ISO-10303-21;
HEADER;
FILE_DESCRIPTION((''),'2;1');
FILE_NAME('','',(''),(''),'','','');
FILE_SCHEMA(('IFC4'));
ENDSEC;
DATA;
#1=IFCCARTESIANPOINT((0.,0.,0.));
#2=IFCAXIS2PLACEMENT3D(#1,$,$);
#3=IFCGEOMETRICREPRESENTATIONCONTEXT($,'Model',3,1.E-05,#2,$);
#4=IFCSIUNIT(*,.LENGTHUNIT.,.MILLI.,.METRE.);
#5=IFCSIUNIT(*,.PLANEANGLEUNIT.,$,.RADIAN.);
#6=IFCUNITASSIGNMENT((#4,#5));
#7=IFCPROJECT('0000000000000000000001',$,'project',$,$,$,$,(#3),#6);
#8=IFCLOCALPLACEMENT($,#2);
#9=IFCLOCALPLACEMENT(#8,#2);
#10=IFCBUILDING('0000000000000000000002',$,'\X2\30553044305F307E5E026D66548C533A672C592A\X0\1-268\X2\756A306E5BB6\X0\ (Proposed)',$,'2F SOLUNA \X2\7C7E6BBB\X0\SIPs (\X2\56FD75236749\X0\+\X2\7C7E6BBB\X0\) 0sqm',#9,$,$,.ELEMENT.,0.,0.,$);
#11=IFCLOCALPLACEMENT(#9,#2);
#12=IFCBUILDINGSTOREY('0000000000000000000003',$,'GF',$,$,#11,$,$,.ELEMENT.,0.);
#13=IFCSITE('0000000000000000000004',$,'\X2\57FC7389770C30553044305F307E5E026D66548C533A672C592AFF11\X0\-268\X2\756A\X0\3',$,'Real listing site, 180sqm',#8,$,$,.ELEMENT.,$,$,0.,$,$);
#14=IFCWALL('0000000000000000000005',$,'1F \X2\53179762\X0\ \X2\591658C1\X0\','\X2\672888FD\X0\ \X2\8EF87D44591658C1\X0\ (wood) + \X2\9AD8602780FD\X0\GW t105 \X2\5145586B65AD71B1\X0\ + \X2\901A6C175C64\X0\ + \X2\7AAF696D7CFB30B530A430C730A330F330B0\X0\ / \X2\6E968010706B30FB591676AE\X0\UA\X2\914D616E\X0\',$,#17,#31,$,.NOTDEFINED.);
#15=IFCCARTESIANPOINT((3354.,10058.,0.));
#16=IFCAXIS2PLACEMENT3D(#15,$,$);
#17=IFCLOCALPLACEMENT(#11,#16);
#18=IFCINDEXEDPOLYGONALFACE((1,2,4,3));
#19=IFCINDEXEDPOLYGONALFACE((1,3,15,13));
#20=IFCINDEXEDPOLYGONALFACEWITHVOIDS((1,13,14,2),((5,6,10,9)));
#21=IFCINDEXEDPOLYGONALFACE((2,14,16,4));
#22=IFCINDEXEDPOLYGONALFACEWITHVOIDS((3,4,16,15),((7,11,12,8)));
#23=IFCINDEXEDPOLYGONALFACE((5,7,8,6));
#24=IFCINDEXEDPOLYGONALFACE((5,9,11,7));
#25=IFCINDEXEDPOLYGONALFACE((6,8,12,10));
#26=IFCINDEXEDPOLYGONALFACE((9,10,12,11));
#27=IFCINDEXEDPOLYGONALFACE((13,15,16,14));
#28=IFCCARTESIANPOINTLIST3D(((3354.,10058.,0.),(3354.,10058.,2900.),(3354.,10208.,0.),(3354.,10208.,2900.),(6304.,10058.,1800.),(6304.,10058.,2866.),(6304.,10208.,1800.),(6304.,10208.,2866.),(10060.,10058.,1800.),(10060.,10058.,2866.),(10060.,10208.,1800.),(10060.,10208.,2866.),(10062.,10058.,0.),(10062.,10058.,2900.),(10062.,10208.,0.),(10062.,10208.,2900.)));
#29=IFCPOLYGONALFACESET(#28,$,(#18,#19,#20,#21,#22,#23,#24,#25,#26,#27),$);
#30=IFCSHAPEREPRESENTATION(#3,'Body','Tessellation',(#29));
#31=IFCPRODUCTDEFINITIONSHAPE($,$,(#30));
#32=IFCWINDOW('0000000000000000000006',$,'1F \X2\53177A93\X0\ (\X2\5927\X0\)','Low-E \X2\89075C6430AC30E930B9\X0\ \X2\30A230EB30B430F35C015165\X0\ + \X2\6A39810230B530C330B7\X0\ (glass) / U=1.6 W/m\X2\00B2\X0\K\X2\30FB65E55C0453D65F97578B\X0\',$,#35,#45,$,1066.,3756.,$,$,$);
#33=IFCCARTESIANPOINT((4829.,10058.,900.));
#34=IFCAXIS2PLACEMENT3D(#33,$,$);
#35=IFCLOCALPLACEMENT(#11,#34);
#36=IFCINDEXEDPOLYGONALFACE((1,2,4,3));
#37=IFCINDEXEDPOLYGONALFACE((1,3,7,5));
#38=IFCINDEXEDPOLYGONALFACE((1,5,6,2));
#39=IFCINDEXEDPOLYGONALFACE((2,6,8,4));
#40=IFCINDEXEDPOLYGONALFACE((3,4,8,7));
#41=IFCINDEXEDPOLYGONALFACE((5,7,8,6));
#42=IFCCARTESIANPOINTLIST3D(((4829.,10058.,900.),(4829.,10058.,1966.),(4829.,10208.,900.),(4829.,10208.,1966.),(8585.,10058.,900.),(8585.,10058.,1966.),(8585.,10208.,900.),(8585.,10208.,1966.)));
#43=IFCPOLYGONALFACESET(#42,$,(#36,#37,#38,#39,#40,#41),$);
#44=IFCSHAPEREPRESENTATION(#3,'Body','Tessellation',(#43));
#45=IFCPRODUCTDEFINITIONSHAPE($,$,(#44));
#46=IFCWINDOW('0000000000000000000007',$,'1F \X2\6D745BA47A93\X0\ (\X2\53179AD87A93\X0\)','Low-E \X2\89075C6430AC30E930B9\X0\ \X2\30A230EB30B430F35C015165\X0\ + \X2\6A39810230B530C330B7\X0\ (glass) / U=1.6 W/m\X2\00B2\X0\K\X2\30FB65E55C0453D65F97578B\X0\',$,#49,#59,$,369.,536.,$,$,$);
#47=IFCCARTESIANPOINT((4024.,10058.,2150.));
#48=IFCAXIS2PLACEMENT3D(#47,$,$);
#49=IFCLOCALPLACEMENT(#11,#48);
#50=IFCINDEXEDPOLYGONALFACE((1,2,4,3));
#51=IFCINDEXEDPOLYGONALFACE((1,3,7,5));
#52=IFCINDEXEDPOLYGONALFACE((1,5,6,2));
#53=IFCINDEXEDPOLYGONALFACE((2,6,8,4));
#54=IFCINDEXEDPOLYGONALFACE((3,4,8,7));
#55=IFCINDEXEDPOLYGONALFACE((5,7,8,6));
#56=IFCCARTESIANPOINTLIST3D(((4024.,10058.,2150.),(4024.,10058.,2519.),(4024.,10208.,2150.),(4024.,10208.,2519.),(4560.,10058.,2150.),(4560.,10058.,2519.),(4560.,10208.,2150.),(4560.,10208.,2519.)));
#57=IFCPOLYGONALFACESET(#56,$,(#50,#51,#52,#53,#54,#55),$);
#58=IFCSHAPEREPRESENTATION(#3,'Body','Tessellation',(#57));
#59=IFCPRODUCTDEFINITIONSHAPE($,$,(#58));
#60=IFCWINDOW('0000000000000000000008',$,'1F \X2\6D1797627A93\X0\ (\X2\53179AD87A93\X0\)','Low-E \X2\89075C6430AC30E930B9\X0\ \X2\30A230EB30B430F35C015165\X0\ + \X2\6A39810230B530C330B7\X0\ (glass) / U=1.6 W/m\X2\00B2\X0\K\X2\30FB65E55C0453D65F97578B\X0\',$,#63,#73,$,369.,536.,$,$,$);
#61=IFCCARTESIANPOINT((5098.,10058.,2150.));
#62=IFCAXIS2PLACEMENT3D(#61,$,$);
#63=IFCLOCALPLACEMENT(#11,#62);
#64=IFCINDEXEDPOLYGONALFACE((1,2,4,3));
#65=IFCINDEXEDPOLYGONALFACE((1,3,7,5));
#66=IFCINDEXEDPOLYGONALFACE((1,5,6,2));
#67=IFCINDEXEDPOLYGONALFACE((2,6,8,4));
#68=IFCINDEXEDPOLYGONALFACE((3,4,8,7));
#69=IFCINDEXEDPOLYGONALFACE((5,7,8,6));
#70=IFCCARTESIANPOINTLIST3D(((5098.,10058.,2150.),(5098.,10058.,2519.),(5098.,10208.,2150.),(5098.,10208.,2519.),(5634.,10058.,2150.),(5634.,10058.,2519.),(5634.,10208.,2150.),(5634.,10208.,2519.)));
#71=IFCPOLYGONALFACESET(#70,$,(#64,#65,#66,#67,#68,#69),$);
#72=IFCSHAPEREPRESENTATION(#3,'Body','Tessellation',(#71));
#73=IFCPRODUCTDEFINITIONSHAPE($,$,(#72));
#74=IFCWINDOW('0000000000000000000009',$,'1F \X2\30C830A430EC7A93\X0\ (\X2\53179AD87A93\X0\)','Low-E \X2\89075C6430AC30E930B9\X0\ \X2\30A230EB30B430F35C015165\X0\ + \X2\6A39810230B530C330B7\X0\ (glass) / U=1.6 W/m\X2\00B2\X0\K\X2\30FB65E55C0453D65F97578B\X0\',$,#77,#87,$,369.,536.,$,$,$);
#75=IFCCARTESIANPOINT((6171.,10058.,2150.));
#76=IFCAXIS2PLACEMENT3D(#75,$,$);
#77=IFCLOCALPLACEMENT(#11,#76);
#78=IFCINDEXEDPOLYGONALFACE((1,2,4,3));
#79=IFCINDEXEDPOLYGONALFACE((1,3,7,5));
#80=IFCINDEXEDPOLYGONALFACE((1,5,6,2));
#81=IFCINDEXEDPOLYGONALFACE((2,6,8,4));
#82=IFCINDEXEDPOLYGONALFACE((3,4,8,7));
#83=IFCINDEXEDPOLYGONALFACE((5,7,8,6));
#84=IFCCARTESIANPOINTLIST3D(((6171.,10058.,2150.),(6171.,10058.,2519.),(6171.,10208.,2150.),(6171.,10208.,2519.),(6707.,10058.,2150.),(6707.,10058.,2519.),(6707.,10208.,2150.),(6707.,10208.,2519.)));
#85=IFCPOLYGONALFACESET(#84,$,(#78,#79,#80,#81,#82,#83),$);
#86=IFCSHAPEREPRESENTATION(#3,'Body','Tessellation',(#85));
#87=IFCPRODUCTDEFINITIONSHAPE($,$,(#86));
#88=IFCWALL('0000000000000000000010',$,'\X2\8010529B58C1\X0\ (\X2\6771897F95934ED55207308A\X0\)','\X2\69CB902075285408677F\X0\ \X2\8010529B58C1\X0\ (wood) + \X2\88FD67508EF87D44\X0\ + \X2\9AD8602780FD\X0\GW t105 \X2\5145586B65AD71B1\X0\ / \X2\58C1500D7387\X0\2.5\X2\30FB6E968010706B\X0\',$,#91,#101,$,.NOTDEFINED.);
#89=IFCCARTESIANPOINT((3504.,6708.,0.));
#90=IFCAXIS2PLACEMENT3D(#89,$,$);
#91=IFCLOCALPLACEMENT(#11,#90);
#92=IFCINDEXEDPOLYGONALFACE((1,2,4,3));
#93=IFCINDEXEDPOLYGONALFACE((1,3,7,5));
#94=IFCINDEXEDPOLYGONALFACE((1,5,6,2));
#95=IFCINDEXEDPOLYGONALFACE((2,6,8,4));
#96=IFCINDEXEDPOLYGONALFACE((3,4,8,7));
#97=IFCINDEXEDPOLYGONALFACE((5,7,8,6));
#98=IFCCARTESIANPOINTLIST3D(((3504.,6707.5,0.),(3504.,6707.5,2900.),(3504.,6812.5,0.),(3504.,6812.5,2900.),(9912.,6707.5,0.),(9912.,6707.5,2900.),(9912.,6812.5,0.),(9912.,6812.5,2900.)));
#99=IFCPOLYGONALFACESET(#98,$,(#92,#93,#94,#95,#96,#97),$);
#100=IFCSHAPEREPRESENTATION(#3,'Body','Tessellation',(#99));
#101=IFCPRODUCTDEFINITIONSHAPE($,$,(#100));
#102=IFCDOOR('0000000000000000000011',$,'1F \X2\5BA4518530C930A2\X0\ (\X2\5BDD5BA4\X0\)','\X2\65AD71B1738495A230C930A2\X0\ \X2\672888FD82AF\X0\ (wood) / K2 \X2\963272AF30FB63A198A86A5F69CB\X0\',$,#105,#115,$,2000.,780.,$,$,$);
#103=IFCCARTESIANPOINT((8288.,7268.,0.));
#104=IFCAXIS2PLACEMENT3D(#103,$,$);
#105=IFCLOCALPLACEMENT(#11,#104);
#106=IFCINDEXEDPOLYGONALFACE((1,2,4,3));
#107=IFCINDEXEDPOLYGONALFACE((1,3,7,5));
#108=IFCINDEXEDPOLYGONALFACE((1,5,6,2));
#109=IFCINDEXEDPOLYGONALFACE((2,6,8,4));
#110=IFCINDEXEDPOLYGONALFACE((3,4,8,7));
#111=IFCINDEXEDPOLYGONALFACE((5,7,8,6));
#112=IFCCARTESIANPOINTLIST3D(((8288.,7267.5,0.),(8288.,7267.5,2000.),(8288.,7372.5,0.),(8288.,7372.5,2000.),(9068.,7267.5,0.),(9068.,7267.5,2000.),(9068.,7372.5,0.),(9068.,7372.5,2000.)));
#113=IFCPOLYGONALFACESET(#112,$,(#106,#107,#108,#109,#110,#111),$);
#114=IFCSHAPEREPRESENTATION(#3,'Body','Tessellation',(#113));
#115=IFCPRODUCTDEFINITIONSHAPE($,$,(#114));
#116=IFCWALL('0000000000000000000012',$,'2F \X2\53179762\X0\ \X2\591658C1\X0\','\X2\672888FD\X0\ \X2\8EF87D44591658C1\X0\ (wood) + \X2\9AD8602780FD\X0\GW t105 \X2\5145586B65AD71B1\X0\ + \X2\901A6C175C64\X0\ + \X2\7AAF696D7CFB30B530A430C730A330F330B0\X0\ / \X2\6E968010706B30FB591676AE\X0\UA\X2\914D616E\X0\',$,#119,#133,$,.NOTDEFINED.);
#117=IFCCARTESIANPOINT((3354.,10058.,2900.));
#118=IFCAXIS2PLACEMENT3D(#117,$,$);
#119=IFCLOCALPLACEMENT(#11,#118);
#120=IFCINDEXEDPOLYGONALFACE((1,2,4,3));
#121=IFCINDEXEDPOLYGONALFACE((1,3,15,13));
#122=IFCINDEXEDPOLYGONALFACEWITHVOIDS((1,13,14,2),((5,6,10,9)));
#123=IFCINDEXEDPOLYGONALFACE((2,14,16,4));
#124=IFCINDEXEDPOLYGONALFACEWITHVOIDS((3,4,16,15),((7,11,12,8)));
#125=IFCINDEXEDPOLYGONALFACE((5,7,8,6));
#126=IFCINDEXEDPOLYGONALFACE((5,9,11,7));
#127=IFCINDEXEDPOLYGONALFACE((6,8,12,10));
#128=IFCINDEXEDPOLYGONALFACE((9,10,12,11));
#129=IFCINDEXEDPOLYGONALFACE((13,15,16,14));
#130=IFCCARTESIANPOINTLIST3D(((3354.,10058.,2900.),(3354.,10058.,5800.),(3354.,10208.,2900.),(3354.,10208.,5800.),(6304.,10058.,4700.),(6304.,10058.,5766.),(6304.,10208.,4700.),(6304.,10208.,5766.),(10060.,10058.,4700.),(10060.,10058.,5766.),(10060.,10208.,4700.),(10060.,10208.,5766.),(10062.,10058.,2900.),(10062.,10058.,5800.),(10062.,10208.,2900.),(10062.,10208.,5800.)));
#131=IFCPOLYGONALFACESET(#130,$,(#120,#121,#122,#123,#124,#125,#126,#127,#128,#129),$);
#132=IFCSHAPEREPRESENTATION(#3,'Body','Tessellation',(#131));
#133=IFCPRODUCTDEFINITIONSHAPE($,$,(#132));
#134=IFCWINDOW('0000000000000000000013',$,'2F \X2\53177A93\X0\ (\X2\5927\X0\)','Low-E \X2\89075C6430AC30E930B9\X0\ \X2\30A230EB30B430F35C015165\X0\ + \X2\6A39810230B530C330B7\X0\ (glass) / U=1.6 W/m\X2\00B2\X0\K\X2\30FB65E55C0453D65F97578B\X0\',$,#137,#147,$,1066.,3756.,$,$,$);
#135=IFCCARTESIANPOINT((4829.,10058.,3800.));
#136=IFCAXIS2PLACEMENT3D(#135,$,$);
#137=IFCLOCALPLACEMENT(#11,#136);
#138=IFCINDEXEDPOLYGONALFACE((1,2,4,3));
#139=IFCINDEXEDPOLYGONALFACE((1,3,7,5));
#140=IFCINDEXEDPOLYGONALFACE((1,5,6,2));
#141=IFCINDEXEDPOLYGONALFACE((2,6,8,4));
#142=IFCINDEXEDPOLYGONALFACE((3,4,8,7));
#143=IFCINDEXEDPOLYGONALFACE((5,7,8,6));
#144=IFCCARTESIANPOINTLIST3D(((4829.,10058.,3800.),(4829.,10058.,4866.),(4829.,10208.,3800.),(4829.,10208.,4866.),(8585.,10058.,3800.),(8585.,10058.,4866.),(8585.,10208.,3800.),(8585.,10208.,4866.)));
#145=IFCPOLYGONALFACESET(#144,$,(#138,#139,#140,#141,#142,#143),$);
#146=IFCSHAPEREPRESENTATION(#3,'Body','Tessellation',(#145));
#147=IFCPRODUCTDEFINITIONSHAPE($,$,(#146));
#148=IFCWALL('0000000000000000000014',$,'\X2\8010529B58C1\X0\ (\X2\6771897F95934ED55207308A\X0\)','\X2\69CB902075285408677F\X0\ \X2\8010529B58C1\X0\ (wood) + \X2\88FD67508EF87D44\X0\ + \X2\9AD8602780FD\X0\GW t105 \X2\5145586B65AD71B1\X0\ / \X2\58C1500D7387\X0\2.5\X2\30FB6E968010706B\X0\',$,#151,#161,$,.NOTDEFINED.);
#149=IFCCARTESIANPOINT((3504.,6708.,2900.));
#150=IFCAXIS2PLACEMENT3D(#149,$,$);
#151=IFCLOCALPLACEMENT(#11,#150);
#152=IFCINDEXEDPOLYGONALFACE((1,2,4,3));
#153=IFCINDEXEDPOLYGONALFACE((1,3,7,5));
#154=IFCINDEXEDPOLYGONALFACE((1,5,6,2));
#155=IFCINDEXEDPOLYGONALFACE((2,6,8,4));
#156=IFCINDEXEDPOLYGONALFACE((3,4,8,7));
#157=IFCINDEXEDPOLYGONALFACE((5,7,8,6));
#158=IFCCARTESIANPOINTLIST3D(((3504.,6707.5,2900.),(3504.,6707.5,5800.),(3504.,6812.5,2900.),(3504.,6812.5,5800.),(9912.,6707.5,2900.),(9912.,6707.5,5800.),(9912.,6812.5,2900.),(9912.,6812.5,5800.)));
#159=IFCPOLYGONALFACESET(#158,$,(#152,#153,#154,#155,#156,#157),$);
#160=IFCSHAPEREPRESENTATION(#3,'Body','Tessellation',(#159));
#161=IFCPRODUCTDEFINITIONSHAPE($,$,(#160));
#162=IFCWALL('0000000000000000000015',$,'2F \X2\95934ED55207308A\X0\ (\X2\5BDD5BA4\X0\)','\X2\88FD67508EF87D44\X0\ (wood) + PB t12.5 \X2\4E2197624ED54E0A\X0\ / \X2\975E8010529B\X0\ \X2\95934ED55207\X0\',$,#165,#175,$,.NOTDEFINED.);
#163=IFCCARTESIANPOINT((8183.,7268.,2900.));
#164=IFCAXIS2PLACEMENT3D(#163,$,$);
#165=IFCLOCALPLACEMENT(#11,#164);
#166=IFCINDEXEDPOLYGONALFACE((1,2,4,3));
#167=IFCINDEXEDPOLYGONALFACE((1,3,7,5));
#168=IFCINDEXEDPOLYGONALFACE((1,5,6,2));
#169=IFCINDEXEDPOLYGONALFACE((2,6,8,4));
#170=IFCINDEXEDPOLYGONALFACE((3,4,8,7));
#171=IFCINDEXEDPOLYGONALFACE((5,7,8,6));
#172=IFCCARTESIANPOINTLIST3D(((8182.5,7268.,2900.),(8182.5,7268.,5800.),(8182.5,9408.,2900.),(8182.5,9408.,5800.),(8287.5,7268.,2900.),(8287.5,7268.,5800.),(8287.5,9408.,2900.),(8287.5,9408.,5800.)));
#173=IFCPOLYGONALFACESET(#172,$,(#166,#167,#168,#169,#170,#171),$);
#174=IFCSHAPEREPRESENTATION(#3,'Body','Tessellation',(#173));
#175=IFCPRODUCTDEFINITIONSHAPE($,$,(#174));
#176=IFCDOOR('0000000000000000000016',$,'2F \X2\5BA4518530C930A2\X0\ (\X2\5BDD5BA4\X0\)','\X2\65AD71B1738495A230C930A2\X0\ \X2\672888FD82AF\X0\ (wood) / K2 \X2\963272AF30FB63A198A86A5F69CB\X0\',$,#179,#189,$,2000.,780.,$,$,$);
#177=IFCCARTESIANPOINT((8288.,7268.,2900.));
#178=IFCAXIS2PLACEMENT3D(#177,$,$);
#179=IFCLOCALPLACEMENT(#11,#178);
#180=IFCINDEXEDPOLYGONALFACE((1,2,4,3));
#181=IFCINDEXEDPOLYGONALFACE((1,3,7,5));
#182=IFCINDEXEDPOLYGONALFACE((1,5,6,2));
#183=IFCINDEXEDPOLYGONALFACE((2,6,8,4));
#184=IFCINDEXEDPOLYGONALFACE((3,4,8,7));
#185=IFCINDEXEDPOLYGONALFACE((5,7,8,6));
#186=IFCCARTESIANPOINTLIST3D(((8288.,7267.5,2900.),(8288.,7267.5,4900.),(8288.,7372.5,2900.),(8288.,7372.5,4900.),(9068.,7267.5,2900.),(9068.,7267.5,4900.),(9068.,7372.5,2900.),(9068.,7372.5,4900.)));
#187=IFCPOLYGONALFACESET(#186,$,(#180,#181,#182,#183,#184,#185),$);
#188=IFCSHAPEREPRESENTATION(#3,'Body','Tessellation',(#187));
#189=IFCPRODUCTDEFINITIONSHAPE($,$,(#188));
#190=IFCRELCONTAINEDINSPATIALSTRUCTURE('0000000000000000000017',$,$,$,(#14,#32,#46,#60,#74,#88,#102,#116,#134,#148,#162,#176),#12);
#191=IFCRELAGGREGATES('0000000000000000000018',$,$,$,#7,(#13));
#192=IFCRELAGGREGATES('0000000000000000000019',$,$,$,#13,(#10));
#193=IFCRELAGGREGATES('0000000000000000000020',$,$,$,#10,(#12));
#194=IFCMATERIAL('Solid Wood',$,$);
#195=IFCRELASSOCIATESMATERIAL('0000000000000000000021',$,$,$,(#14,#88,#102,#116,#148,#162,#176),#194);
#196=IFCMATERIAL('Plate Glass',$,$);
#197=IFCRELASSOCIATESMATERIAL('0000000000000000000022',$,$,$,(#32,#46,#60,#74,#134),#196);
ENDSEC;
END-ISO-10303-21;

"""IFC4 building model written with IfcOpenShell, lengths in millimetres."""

from ifc_helpers import new_model, si_unit, frame, frame_2d, origin, place, context, project, spatial, rectangle, extrude, material, element, fill, save


model = new_model("IFC4")

# Units and contexts
model_context = context("Model", 3, precision=1e-05, world=origin())
ifc_project = project(units=[si_unit("LENGTHUNIT", "METRE", prefix="MILLI"), si_unit("PLANEANGLEUNIT", "RADIAN")], contexts=[model_context])

# Site, building, storey
site_placement = place(None, origin())
site = spatial("IfcSite", under=ifc_project, at=site_placement, Name="埼玉県さいたま市浦和区本太１-268番3", ObjectType="Real listing site, 180sqm", CompositionType="ELEMENT", RefElevation=0.0)
building_placement = place(site_placement, origin())
building = spatial("IfcBuilding", under=site, at=building_placement, Name="さいたま市浦和区本太1-268番の家 (Proposed)", ObjectType="2F SOLUNA 籾殻SIPs (国産杉+籾殻) 0sqm", CompositionType="ELEMENT", ElevationOfRefHeight=0.0, ElevationOfTerrain=0.0)
storey_placement = place(building_placement, origin())
storey = spatial("IfcBuildingStorey", under=building, at=storey_placement, Name="GF", CompositionType="ELEMENT", Elevation=0.0)

# Wall, openings, windows
ifc_material_1 = material(Name="Solid Wood")
wall_1_placement = place(storey_placement, frame((3354.0, 10058.0, 0.0)))
wall_1 = element("IfcWall", 1, at=wall_1_placement, inside=storey, material=ifc_material_1, Name="1F 北面 外壁", Description="木製 軸組外壁 (wood) + 高性能GW t105 充填断熱 + 通気層 + 窯業系サイディング / 準耐火・外皮UA配慮", PredefinedType="NOTDEFINED", context=model_context, shape_type="SweptSolid", body=[
    extrude(rectangle(XDim=6708.0, YDim=150.0, at=frame_2d((3354.0, 75.0))), frame((3354.0, 10058.0, 0.0)), (0.0, 0.0, 1.0), 2900.0),
])
opening_1_placement = place(storey_placement, frame((4829.0, 10058.0, 900.0)))
opening_1 = element("IfcOpeningElement", 2, at=opening_1_placement, cuts=wall_1, PredefinedType="NOTDEFINED", context=model_context, shape_type="SweptSolid", body=[
    extrude(rectangle(XDim=3756.0, YDim=150.0, at=frame_2d((1878.0, 75.0))), frame((4829.0, 10058.0, 900.0)), (0.0, 0.0, 1.0), 1066.0),
])
opening_2_placement = place(storey_placement, frame((4024.0, 10058.0, 2150.0)))
opening_2 = element("IfcOpeningElement", 3, at=opening_2_placement, cuts=wall_1, PredefinedType="NOTDEFINED", context=model_context, shape_type="SweptSolid", body=[
    extrude(rectangle(XDim=536.0, YDim=150.0, at=frame_2d((268.0, 75.0))), frame((4024.0, 10058.0, 2150.0)), (0.0, 0.0, 1.0), 369.0),
])
opening_3_placement = place(storey_placement, frame((5098.0, 10058.0, 2150.0)))
opening_3 = element("IfcOpeningElement", 4, at=opening_3_placement, cuts=wall_1, PredefinedType="NOTDEFINED", context=model_context, shape_type="SweptSolid", body=[
    extrude(rectangle(XDim=536.0, YDim=150.0, at=frame_2d((268.0, 75.0))), frame((5098.0, 10058.0, 2150.0)), (0.0, 0.0, 1.0), 369.0),
])
opening_4_placement = place(storey_placement, frame((6171.0, 10058.0, 2150.0)))
opening_4 = element("IfcOpeningElement", 5, at=opening_4_placement, cuts=wall_1, PredefinedType="NOTDEFINED", context=model_context, shape_type="SweptSolid", body=[
    extrude(rectangle(XDim=536.0, YDim=150.0, at=frame_2d((268.0, 75.0))), frame((6171.0, 10058.0, 2150.0)), (0.0, 0.0, 1.0), 369.0),
])
ifc_material_2 = material(Name="Plate Glass")
window_1_placement = place(storey_placement, frame((4829.0, 10058.0, 900.0)))
window_1 = element("IfcWindow", 6, at=window_1_placement, inside=storey, material=ifc_material_2, Name="1F 北窓 (大)", Description="Low-E 複層ガラス アルゴン封入 + 樹脂サッシ (glass) / U=1.6 W/m²K・日射取得型", OverallHeight=1066.0, OverallWidth=3756.0, context=model_context, shape_type="SweptSolid", body=[
    extrude(rectangle(XDim=3756.0, YDim=150.0, at=frame_2d((1878.0, 75.0))), frame((4829.0, 10058.0, 900.0)), (0.0, 0.0, 1.0), 1066.0),
])
fill(opening_1, window_1)
window_2_placement = place(storey_placement, frame((4024.0, 10058.0, 2150.0)))
window_2 = element("IfcWindow", 7, at=window_2_placement, inside=storey, material=ifc_material_2, Name="1F 浴室窓 (北高窓)", Description="Low-E 複層ガラス アルゴン封入 + 樹脂サッシ (glass) / U=1.6 W/m²K・日射取得型", OverallHeight=369.0, OverallWidth=536.0, context=model_context, shape_type="SweptSolid", body=[
    extrude(rectangle(XDim=536.0, YDim=150.0, at=frame_2d((268.0, 75.0))), frame((4024.0, 10058.0, 2150.0)), (0.0, 0.0, 1.0), 369.0),
])
fill(opening_2, window_2)
window_3_placement = place(storey_placement, frame((5098.0, 10058.0, 2150.0)))
window_3 = element("IfcWindow", 8, at=window_3_placement, inside=storey, material=ifc_material_2, Name="1F 洗面窓 (北高窓)", Description="Low-E 複層ガラス アルゴン封入 + 樹脂サッシ (glass) / U=1.6 W/m²K・日射取得型", OverallHeight=369.0, OverallWidth=536.0, context=model_context, shape_type="SweptSolid", body=[
    extrude(rectangle(XDim=536.0, YDim=150.0, at=frame_2d((268.0, 75.0))), frame((5098.0, 10058.0, 2150.0)), (0.0, 0.0, 1.0), 369.0),
])
fill(opening_3, window_3)
window_4_placement = place(storey_placement, frame((6171.0, 10058.0, 2150.0)))
window_4 = element("IfcWindow", 9, at=window_4_placement, inside=storey, material=ifc_material_2, Name="1F トイレ窓 (北高窓)", Description="Low-E 複層ガラス アルゴン封入 + 樹脂サッシ (glass) / U=1.6 W/m²K・日射取得型", OverallHeight=369.0, OverallWidth=536.0, context=model_context, shape_type="SweptSolid", body=[
    extrude(rectangle(XDim=536.0, YDim=150.0, at=frame_2d((268.0, 75.0))), frame((6171.0, 10058.0, 2150.0)), (0.0, 0.0, 1.0), 369.0),
])
fill(opening_4, window_4)

# Wall
wall_2_placement = place(storey_placement, frame((3504.0, 6708.0, 0.0)))
element("IfcWall", 10, at=wall_2_placement, inside=storey, material=ifc_material_1, Name="耐力壁 (東西間仕切り)", Description="構造用合板 耐力壁 (wood) + 製材軸組 + 高性能GW t105 充填断熱 / 壁倍率2.5・準耐火", PredefinedType="NOTDEFINED", context=model_context, shape_type="SweptSolid", body=[
    extrude(rectangle(XDim=6408.0, YDim=105.0, at=frame_2d((3204.0, 52.0))), frame((3504.0, 6708.0, 0.0)), (0.0, 0.0, 1.0), 2900.0),
])

# Door
door_1_placement = place(storey_placement, frame((8288.0, 7268.0, 0.0)))
element("IfcDoor", 11, at=door_1_placement, inside=storey, material=ifc_material_1, Name="1F 室内ドア (寝室)", Description="断熱玄関ドア 木製芯 (wood) / K2 防犯・採風機構", OverallHeight=2000.0, OverallWidth=780.0, context=model_context, shape_type="SweptSolid", body=[
    extrude(rectangle(XDim=780.0, YDim=105.0, at=frame_2d((390.0, 52.0))), frame((8288.0, 7268.0, 0.0)), (0.0, 0.0, 1.0), 2000.0),
])

# Wall, opening, window
wall_3_placement = place(storey_placement, frame((3354.0, 10058.0, 2900.0)))
wall_3 = element("IfcWall", 12, at=wall_3_placement, inside=storey, material=ifc_material_1, Name="2F 北面 外壁", Description="木製 軸組外壁 (wood) + 高性能GW t105 充填断熱 + 通気層 + 窯業系サイディング / 準耐火・外皮UA配慮", PredefinedType="NOTDEFINED", context=model_context, shape_type="SweptSolid", body=[
    extrude(rectangle(XDim=6708.0, YDim=150.0, at=frame_2d((3354.0, 75.0))), frame((3354.0, 10058.0, 2900.0)), (0.0, 0.0, 1.0), 2900.0),
])
opening_5_placement = place(storey_placement, frame((4829.0, 10058.0, 3800.0)))
opening_5 = element("IfcOpeningElement", 13, at=opening_5_placement, cuts=wall_3, PredefinedType="NOTDEFINED", context=model_context, shape_type="SweptSolid", body=[
    extrude(rectangle(XDim=3756.0, YDim=150.0, at=frame_2d((1878.0, 75.0))), frame((4829.0, 10058.0, 3800.0)), (0.0, 0.0, 1.0), 1066.0),
])
window_5_placement = place(storey_placement, frame((4829.0, 10058.0, 3800.0)))
window_5 = element("IfcWindow", 14, at=window_5_placement, inside=storey, material=ifc_material_2, Name="2F 北窓 (大)", Description="Low-E 複層ガラス アルゴン封入 + 樹脂サッシ (glass) / U=1.6 W/m²K・日射取得型", OverallHeight=1066.0, OverallWidth=3756.0, context=model_context, shape_type="SweptSolid", body=[
    extrude(rectangle(XDim=3756.0, YDim=150.0, at=frame_2d((1878.0, 75.0))), frame((4829.0, 10058.0, 3800.0)), (0.0, 0.0, 1.0), 1066.0),
])
fill(opening_5, window_5)

# Walls
wall_4_placement = place(storey_placement, frame((3504.0, 6708.0, 2900.0)))
element("IfcWall", 15, at=wall_4_placement, inside=storey, material=ifc_material_1, Name="耐力壁 (東西間仕切り)", Description="構造用合板 耐力壁 (wood) + 製材軸組 + 高性能GW t105 充填断熱 / 壁倍率2.5・準耐火", PredefinedType="NOTDEFINED", context=model_context, shape_type="SweptSolid", body=[
    extrude(rectangle(XDim=6408.0, YDim=105.0, at=frame_2d((3204.0, 52.0))), frame((3504.0, 6708.0, 2900.0)), (0.0, 0.0, 1.0), 2900.0),
])
wall_5_placement = place(storey_placement, frame((8183.0, 7268.0, 2900.0)))
element("IfcWall", 16, at=wall_5_placement, inside=storey, material=ifc_material_1, Name="2F 間仕切り (寝室)", Description="製材軸組 (wood) + PB t12.5 両面仕上 / 非耐力 間仕切", PredefinedType="NOTDEFINED", context=model_context, shape_type="SweptSolid", body=[
    extrude(rectangle(XDim=105.0, YDim=2140.0, at=frame_2d((52.0, 1070.0))), frame((8183.0, 7268.0, 2900.0)), (0.0, 0.0, 1.0), 2900.0),
])

# Door
door_2_placement = place(storey_placement, frame((8288.0, 7268.0, 2900.0)))
element("IfcDoor", 17, at=door_2_placement, inside=storey, material=ifc_material_1, Name="2F 室内ドア (寝室)", Description="断熱玄関ドア 木製芯 (wood) / K2 防犯・採風機構", OverallHeight=2000.0, OverallWidth=780.0, context=model_context, shape_type="SweptSolid", body=[
    extrude(rectangle(XDim=780.0, YDim=105.0, at=frame_2d((390.0, 52.0))), frame((8288.0, 7268.0, 2900.0)), (0.0, 0.0, 1.0), 2000.0),
])

save(model, "model.ifc")
